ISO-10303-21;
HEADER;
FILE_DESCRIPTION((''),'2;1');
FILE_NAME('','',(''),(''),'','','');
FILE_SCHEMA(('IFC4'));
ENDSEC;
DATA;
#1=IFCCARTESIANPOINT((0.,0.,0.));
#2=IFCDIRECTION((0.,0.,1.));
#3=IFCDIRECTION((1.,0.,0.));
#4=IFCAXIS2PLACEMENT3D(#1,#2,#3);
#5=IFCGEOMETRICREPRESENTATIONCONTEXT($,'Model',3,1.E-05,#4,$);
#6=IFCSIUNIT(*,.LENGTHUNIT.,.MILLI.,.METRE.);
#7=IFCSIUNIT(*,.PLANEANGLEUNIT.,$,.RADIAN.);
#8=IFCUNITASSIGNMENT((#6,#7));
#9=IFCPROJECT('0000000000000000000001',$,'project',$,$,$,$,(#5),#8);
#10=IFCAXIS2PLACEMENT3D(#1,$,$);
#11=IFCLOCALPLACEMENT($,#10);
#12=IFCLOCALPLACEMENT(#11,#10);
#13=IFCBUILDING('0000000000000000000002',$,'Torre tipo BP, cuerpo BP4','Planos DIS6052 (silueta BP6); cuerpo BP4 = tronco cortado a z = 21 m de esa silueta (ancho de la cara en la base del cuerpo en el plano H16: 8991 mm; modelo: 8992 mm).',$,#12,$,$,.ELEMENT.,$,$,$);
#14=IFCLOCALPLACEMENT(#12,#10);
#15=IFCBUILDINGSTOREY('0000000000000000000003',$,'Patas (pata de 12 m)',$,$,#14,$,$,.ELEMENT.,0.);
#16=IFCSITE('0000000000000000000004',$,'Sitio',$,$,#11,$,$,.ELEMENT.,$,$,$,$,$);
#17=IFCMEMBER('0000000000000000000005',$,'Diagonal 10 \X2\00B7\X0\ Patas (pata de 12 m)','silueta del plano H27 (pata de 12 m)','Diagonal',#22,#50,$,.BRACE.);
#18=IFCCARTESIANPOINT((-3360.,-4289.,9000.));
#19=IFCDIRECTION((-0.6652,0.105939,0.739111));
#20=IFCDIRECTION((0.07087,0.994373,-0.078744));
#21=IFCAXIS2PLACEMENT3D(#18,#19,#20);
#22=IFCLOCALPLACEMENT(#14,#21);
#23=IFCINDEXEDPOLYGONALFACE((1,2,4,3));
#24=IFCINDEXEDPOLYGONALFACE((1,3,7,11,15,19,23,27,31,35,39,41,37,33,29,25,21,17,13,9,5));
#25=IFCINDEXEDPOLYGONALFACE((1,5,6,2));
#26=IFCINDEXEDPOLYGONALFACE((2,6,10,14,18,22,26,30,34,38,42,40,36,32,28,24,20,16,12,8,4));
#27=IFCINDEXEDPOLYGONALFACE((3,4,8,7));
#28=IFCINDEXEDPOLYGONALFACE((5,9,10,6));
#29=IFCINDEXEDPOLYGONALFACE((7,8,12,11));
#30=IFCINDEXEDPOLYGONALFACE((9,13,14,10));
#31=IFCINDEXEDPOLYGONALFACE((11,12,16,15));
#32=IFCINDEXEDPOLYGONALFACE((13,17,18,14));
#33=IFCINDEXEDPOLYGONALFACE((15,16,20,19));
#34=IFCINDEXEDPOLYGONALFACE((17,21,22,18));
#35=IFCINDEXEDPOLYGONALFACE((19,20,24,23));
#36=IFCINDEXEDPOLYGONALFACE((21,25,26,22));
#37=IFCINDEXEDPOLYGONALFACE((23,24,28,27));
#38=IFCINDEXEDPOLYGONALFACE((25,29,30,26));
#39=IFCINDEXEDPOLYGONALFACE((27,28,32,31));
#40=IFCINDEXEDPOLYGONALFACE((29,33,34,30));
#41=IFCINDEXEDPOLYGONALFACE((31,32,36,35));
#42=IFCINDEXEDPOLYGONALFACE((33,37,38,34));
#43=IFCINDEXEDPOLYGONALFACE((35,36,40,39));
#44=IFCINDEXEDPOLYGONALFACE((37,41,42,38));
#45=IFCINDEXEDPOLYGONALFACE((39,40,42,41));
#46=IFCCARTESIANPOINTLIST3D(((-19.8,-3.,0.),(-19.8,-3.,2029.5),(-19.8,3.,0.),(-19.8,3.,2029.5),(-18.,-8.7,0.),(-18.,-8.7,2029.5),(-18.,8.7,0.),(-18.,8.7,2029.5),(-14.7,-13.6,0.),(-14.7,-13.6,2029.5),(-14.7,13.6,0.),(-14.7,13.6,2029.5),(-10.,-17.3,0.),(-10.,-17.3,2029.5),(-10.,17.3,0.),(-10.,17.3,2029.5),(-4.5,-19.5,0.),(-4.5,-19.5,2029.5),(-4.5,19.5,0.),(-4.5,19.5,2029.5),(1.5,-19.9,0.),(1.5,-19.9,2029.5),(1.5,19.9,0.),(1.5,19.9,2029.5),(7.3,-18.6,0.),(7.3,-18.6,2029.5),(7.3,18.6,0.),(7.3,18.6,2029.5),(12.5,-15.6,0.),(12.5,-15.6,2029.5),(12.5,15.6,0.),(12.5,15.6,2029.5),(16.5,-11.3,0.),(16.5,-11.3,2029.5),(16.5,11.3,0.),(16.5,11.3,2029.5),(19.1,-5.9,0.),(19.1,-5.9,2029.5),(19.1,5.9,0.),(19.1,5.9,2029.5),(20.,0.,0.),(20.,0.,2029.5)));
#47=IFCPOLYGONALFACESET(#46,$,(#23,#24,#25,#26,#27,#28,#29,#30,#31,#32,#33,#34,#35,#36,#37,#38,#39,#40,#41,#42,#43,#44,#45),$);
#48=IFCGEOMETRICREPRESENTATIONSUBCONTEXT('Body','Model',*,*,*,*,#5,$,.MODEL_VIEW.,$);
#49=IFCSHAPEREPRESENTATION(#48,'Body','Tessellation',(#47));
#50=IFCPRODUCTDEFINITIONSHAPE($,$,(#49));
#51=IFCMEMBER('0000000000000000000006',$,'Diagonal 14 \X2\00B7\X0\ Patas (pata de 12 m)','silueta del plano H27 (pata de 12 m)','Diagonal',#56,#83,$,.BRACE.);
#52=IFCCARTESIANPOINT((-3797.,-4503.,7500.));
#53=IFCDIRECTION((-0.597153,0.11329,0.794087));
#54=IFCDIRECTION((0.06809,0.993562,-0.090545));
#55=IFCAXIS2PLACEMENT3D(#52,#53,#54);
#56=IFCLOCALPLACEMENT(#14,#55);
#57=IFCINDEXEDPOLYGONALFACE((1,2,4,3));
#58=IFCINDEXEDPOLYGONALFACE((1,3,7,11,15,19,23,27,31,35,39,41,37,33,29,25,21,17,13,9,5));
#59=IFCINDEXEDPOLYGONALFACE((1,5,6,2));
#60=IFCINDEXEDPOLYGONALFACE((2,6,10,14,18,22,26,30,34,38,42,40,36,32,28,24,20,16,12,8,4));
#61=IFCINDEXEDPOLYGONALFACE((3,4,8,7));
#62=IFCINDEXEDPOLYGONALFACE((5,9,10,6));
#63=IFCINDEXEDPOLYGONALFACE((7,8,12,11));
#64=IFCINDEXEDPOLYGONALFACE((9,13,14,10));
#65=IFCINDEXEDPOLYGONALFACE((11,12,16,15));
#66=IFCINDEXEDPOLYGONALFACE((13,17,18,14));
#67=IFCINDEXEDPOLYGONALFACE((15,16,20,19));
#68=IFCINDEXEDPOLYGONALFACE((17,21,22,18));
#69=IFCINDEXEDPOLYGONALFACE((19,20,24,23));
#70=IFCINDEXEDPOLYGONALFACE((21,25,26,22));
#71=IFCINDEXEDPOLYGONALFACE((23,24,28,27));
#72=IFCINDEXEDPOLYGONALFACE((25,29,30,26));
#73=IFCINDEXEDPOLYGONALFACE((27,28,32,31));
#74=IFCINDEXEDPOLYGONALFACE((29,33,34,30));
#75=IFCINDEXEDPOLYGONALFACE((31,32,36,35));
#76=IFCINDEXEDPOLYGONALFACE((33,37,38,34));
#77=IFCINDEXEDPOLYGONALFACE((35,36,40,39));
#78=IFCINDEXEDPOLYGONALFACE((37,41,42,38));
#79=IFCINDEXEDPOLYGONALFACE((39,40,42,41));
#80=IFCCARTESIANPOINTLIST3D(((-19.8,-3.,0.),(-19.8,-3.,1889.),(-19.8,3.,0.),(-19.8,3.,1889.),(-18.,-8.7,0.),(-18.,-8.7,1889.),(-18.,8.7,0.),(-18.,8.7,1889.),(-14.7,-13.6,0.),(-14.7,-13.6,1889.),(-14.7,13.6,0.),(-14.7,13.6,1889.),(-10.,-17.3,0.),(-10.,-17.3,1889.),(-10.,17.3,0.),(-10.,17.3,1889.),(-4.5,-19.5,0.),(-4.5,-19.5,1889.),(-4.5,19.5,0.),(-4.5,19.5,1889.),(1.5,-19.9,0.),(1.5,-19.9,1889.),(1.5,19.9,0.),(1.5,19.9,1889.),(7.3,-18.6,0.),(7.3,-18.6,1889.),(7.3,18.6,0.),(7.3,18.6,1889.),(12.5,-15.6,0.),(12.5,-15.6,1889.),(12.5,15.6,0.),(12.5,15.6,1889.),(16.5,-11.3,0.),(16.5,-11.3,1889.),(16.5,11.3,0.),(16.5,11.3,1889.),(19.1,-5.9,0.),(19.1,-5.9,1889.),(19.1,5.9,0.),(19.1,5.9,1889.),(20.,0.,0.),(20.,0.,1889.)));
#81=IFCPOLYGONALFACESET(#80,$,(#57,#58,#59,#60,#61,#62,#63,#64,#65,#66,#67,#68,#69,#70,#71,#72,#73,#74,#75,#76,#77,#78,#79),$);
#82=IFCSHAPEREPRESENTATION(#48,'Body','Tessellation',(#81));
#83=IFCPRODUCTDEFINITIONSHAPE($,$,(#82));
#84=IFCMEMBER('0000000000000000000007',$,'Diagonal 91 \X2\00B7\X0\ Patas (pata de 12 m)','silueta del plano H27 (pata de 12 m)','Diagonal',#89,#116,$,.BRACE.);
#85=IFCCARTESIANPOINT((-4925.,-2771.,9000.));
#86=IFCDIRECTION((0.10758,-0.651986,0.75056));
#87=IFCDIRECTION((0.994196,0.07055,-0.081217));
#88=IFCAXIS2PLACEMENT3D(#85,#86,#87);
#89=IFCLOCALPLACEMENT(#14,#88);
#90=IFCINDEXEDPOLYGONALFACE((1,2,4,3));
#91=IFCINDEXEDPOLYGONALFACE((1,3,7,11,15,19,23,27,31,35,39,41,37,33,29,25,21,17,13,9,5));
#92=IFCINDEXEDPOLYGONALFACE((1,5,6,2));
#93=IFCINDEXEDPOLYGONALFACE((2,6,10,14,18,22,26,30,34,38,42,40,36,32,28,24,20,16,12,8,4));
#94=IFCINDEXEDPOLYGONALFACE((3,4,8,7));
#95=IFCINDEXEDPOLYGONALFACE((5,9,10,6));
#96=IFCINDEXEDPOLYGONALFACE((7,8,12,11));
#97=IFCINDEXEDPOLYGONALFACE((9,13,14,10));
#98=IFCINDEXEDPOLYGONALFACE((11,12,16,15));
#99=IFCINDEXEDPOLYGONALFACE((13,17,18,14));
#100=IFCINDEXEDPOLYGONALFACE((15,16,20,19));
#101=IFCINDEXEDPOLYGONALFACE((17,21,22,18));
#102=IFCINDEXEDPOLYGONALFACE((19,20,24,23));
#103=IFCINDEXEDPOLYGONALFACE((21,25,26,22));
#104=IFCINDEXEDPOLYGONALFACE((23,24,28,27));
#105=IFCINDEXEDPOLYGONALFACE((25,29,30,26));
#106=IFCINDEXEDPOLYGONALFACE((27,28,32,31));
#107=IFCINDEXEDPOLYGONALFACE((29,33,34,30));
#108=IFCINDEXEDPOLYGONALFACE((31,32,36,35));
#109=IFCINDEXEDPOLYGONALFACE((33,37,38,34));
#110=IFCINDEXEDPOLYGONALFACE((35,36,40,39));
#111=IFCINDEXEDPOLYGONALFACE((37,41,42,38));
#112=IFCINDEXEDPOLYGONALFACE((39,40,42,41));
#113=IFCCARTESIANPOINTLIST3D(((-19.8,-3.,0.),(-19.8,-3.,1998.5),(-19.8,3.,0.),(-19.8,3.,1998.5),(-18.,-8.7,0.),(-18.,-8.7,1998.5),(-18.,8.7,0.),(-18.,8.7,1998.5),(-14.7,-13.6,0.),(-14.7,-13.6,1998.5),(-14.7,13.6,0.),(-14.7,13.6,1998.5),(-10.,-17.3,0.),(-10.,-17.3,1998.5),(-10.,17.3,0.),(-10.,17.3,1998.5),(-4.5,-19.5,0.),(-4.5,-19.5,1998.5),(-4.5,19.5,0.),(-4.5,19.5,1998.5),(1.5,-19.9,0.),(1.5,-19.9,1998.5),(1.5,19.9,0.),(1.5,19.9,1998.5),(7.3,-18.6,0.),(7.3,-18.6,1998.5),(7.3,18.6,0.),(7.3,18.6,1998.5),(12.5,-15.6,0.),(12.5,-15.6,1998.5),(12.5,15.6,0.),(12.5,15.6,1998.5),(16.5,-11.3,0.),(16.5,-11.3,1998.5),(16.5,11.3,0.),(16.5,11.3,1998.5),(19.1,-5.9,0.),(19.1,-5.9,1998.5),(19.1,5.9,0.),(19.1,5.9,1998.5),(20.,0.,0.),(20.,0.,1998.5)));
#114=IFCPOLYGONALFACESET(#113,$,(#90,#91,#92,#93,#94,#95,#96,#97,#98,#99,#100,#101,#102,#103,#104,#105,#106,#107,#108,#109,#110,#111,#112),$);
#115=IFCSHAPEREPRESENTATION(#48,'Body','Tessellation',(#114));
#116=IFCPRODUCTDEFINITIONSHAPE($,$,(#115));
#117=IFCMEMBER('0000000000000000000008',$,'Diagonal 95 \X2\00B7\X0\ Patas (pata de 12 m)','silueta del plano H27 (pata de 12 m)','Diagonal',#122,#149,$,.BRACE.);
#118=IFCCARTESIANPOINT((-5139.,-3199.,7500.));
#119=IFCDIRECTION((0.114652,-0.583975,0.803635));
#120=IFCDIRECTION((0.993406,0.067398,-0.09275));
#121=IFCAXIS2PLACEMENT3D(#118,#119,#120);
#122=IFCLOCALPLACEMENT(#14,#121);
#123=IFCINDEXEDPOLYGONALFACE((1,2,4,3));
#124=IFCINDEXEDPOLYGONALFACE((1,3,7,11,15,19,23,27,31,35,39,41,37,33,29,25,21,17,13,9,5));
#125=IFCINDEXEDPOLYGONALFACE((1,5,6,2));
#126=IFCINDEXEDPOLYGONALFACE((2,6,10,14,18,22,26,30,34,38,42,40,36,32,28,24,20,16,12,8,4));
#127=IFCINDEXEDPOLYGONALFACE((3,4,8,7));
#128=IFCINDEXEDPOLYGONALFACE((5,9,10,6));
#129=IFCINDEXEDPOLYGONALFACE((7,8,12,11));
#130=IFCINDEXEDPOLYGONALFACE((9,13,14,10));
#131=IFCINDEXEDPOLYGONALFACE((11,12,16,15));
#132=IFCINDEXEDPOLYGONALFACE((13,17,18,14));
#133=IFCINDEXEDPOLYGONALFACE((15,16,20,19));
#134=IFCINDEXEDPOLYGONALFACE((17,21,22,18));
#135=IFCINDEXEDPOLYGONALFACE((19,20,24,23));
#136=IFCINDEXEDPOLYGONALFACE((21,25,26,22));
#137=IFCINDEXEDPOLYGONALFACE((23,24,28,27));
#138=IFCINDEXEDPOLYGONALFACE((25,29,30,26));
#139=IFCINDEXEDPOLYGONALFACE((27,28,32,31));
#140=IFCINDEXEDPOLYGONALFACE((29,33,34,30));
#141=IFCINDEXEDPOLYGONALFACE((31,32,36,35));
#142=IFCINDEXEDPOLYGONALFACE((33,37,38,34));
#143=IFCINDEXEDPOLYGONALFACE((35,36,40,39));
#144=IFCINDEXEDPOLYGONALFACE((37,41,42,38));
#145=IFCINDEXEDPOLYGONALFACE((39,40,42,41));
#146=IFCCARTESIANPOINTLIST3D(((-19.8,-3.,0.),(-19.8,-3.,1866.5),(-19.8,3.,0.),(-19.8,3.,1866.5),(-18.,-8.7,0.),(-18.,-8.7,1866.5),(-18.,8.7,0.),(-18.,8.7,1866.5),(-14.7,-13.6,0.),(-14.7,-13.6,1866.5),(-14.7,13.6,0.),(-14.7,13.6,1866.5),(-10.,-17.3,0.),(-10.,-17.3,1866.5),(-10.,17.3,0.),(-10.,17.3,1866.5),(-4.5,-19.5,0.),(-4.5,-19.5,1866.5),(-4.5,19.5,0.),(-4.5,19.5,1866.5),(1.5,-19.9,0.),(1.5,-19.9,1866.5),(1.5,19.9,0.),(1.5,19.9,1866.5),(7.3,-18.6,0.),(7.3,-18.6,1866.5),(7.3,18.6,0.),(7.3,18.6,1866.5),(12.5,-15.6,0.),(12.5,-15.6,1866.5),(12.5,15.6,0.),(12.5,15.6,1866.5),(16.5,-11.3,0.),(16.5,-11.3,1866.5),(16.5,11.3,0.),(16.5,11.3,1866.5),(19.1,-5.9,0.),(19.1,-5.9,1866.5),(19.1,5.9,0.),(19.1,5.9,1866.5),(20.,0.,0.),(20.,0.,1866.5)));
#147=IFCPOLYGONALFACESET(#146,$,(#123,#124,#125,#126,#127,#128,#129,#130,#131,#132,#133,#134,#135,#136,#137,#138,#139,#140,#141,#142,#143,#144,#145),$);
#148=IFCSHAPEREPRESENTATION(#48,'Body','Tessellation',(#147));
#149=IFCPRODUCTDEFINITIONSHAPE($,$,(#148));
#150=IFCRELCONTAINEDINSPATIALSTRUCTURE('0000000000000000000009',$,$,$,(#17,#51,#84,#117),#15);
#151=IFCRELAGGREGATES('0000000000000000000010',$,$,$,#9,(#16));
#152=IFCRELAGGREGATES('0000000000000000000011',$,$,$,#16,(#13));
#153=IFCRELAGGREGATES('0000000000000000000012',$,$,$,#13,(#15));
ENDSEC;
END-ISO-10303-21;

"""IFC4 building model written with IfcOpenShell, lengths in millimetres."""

from ifc_helpers import new_model, si_unit, frame, origin, origin_with_axes, place, context, subcontext, project, spatial, circle, extrude, element, save


model = new_model("IFC4")

# Units and contexts
model_context = context("Model", 3, precision=1e-05, world=origin_with_axes())
body_context = subcontext(model_context, "Body", "Model", "MODEL_VIEW")
ifc_project = project(units=[si_unit("LENGTHUNIT", "METRE", prefix="MILLI"), si_unit("PLANEANGLEUNIT", "RADIAN")], contexts=[model_context])

# Site, building, storey
site_placement = place(None, origin())
site = spatial("IfcSite", under=ifc_project, at=site_placement, Name="Sitio", CompositionType="ELEMENT")
building_placement = place(site_placement, origin())
building = spatial("IfcBuilding", under=site, at=building_placement, Name="Torre tipo BP, cuerpo BP4", Description="Planos DIS6052 (silueta BP6); cuerpo BP4 = tronco cortado a z = 21 m de esa silueta (ancho de la cara en la base del cuerpo en el plano H16: 8991 mm; modelo: 8992 mm).", CompositionType="ELEMENT")
storey_placement = place(building_placement, origin())
storey = spatial("IfcBuildingStorey", under=building, at=storey_placement, Name="Patas (pata de 12 m)", CompositionType="ELEMENT", Elevation=0.0)

# Members
member_1_placement = place(storey_placement, frame((-3360.0, -4289.0, 9000.0), z_axis=(-0.6652, 0.105939, 0.739111), x_axis=(0.07087, 0.994373, -0.078744)))
element("IfcMember", 1, at=member_1_placement, inside=storey, Name="Diagonal 10 · Patas (pata de 12 m)", Description="silueta del plano H27 (pata de 12 m)", ObjectType="Diagonal", PredefinedType="BRACE", context=body_context, shape_type="SweptSolid", body=[
    extrude(circle(Radius=20.0), None, (0.0, 0.0, 1.0), 2029.5),
])
member_2_placement = place(storey_placement, frame((-3797.0, -4503.0, 7500.0), z_axis=(-0.597153, 0.11329, 0.794087), x_axis=(0.06809, 0.993562, -0.090545)))
element("IfcMember", 2, at=member_2_placement, inside=storey, Name="Diagonal 14 · Patas (pata de 12 m)", Description="silueta del plano H27 (pata de 12 m)", ObjectType="Diagonal", PredefinedType="BRACE", context=body_context, shape_type="SweptSolid", body=[
    extrude(circle(Radius=20.0), None, (0.0, 0.0, 1.0), 1889.0),
])
member_3_placement = place(storey_placement, frame((-4925.0, -2771.0, 9000.0), z_axis=(0.10758, -0.651986, 0.75056), x_axis=(0.994196, 0.07055, -0.081217)))
element("IfcMember", 3, at=member_3_placement, inside=storey, Name="Diagonal 91 · Patas (pata de 12 m)", Description="silueta del plano H27 (pata de 12 m)", ObjectType="Diagonal", PredefinedType="BRACE", context=body_context, shape_type="SweptSolid", body=[
    extrude(circle(Radius=20.0), None, (0.0, 0.0, 1.0), 1998.5),
])
member_4_placement = place(storey_placement, frame((-5139.0, -3199.0, 7500.0), z_axis=(0.114652, -0.583975, 0.803635), x_axis=(0.993406, 0.067398, -0.09275)))
element("IfcMember", 4, at=member_4_placement, inside=storey, Name="Diagonal 95 · Patas (pata de 12 m)", Description="silueta del plano H27 (pata de 12 m)", ObjectType="Diagonal", PredefinedType="BRACE", context=body_context, shape_type="SweptSolid", body=[
    extrude(circle(Radius=20.0), None, (0.0, 0.0, 1.0), 1866.5),
])

save(model, "model.ifc")
